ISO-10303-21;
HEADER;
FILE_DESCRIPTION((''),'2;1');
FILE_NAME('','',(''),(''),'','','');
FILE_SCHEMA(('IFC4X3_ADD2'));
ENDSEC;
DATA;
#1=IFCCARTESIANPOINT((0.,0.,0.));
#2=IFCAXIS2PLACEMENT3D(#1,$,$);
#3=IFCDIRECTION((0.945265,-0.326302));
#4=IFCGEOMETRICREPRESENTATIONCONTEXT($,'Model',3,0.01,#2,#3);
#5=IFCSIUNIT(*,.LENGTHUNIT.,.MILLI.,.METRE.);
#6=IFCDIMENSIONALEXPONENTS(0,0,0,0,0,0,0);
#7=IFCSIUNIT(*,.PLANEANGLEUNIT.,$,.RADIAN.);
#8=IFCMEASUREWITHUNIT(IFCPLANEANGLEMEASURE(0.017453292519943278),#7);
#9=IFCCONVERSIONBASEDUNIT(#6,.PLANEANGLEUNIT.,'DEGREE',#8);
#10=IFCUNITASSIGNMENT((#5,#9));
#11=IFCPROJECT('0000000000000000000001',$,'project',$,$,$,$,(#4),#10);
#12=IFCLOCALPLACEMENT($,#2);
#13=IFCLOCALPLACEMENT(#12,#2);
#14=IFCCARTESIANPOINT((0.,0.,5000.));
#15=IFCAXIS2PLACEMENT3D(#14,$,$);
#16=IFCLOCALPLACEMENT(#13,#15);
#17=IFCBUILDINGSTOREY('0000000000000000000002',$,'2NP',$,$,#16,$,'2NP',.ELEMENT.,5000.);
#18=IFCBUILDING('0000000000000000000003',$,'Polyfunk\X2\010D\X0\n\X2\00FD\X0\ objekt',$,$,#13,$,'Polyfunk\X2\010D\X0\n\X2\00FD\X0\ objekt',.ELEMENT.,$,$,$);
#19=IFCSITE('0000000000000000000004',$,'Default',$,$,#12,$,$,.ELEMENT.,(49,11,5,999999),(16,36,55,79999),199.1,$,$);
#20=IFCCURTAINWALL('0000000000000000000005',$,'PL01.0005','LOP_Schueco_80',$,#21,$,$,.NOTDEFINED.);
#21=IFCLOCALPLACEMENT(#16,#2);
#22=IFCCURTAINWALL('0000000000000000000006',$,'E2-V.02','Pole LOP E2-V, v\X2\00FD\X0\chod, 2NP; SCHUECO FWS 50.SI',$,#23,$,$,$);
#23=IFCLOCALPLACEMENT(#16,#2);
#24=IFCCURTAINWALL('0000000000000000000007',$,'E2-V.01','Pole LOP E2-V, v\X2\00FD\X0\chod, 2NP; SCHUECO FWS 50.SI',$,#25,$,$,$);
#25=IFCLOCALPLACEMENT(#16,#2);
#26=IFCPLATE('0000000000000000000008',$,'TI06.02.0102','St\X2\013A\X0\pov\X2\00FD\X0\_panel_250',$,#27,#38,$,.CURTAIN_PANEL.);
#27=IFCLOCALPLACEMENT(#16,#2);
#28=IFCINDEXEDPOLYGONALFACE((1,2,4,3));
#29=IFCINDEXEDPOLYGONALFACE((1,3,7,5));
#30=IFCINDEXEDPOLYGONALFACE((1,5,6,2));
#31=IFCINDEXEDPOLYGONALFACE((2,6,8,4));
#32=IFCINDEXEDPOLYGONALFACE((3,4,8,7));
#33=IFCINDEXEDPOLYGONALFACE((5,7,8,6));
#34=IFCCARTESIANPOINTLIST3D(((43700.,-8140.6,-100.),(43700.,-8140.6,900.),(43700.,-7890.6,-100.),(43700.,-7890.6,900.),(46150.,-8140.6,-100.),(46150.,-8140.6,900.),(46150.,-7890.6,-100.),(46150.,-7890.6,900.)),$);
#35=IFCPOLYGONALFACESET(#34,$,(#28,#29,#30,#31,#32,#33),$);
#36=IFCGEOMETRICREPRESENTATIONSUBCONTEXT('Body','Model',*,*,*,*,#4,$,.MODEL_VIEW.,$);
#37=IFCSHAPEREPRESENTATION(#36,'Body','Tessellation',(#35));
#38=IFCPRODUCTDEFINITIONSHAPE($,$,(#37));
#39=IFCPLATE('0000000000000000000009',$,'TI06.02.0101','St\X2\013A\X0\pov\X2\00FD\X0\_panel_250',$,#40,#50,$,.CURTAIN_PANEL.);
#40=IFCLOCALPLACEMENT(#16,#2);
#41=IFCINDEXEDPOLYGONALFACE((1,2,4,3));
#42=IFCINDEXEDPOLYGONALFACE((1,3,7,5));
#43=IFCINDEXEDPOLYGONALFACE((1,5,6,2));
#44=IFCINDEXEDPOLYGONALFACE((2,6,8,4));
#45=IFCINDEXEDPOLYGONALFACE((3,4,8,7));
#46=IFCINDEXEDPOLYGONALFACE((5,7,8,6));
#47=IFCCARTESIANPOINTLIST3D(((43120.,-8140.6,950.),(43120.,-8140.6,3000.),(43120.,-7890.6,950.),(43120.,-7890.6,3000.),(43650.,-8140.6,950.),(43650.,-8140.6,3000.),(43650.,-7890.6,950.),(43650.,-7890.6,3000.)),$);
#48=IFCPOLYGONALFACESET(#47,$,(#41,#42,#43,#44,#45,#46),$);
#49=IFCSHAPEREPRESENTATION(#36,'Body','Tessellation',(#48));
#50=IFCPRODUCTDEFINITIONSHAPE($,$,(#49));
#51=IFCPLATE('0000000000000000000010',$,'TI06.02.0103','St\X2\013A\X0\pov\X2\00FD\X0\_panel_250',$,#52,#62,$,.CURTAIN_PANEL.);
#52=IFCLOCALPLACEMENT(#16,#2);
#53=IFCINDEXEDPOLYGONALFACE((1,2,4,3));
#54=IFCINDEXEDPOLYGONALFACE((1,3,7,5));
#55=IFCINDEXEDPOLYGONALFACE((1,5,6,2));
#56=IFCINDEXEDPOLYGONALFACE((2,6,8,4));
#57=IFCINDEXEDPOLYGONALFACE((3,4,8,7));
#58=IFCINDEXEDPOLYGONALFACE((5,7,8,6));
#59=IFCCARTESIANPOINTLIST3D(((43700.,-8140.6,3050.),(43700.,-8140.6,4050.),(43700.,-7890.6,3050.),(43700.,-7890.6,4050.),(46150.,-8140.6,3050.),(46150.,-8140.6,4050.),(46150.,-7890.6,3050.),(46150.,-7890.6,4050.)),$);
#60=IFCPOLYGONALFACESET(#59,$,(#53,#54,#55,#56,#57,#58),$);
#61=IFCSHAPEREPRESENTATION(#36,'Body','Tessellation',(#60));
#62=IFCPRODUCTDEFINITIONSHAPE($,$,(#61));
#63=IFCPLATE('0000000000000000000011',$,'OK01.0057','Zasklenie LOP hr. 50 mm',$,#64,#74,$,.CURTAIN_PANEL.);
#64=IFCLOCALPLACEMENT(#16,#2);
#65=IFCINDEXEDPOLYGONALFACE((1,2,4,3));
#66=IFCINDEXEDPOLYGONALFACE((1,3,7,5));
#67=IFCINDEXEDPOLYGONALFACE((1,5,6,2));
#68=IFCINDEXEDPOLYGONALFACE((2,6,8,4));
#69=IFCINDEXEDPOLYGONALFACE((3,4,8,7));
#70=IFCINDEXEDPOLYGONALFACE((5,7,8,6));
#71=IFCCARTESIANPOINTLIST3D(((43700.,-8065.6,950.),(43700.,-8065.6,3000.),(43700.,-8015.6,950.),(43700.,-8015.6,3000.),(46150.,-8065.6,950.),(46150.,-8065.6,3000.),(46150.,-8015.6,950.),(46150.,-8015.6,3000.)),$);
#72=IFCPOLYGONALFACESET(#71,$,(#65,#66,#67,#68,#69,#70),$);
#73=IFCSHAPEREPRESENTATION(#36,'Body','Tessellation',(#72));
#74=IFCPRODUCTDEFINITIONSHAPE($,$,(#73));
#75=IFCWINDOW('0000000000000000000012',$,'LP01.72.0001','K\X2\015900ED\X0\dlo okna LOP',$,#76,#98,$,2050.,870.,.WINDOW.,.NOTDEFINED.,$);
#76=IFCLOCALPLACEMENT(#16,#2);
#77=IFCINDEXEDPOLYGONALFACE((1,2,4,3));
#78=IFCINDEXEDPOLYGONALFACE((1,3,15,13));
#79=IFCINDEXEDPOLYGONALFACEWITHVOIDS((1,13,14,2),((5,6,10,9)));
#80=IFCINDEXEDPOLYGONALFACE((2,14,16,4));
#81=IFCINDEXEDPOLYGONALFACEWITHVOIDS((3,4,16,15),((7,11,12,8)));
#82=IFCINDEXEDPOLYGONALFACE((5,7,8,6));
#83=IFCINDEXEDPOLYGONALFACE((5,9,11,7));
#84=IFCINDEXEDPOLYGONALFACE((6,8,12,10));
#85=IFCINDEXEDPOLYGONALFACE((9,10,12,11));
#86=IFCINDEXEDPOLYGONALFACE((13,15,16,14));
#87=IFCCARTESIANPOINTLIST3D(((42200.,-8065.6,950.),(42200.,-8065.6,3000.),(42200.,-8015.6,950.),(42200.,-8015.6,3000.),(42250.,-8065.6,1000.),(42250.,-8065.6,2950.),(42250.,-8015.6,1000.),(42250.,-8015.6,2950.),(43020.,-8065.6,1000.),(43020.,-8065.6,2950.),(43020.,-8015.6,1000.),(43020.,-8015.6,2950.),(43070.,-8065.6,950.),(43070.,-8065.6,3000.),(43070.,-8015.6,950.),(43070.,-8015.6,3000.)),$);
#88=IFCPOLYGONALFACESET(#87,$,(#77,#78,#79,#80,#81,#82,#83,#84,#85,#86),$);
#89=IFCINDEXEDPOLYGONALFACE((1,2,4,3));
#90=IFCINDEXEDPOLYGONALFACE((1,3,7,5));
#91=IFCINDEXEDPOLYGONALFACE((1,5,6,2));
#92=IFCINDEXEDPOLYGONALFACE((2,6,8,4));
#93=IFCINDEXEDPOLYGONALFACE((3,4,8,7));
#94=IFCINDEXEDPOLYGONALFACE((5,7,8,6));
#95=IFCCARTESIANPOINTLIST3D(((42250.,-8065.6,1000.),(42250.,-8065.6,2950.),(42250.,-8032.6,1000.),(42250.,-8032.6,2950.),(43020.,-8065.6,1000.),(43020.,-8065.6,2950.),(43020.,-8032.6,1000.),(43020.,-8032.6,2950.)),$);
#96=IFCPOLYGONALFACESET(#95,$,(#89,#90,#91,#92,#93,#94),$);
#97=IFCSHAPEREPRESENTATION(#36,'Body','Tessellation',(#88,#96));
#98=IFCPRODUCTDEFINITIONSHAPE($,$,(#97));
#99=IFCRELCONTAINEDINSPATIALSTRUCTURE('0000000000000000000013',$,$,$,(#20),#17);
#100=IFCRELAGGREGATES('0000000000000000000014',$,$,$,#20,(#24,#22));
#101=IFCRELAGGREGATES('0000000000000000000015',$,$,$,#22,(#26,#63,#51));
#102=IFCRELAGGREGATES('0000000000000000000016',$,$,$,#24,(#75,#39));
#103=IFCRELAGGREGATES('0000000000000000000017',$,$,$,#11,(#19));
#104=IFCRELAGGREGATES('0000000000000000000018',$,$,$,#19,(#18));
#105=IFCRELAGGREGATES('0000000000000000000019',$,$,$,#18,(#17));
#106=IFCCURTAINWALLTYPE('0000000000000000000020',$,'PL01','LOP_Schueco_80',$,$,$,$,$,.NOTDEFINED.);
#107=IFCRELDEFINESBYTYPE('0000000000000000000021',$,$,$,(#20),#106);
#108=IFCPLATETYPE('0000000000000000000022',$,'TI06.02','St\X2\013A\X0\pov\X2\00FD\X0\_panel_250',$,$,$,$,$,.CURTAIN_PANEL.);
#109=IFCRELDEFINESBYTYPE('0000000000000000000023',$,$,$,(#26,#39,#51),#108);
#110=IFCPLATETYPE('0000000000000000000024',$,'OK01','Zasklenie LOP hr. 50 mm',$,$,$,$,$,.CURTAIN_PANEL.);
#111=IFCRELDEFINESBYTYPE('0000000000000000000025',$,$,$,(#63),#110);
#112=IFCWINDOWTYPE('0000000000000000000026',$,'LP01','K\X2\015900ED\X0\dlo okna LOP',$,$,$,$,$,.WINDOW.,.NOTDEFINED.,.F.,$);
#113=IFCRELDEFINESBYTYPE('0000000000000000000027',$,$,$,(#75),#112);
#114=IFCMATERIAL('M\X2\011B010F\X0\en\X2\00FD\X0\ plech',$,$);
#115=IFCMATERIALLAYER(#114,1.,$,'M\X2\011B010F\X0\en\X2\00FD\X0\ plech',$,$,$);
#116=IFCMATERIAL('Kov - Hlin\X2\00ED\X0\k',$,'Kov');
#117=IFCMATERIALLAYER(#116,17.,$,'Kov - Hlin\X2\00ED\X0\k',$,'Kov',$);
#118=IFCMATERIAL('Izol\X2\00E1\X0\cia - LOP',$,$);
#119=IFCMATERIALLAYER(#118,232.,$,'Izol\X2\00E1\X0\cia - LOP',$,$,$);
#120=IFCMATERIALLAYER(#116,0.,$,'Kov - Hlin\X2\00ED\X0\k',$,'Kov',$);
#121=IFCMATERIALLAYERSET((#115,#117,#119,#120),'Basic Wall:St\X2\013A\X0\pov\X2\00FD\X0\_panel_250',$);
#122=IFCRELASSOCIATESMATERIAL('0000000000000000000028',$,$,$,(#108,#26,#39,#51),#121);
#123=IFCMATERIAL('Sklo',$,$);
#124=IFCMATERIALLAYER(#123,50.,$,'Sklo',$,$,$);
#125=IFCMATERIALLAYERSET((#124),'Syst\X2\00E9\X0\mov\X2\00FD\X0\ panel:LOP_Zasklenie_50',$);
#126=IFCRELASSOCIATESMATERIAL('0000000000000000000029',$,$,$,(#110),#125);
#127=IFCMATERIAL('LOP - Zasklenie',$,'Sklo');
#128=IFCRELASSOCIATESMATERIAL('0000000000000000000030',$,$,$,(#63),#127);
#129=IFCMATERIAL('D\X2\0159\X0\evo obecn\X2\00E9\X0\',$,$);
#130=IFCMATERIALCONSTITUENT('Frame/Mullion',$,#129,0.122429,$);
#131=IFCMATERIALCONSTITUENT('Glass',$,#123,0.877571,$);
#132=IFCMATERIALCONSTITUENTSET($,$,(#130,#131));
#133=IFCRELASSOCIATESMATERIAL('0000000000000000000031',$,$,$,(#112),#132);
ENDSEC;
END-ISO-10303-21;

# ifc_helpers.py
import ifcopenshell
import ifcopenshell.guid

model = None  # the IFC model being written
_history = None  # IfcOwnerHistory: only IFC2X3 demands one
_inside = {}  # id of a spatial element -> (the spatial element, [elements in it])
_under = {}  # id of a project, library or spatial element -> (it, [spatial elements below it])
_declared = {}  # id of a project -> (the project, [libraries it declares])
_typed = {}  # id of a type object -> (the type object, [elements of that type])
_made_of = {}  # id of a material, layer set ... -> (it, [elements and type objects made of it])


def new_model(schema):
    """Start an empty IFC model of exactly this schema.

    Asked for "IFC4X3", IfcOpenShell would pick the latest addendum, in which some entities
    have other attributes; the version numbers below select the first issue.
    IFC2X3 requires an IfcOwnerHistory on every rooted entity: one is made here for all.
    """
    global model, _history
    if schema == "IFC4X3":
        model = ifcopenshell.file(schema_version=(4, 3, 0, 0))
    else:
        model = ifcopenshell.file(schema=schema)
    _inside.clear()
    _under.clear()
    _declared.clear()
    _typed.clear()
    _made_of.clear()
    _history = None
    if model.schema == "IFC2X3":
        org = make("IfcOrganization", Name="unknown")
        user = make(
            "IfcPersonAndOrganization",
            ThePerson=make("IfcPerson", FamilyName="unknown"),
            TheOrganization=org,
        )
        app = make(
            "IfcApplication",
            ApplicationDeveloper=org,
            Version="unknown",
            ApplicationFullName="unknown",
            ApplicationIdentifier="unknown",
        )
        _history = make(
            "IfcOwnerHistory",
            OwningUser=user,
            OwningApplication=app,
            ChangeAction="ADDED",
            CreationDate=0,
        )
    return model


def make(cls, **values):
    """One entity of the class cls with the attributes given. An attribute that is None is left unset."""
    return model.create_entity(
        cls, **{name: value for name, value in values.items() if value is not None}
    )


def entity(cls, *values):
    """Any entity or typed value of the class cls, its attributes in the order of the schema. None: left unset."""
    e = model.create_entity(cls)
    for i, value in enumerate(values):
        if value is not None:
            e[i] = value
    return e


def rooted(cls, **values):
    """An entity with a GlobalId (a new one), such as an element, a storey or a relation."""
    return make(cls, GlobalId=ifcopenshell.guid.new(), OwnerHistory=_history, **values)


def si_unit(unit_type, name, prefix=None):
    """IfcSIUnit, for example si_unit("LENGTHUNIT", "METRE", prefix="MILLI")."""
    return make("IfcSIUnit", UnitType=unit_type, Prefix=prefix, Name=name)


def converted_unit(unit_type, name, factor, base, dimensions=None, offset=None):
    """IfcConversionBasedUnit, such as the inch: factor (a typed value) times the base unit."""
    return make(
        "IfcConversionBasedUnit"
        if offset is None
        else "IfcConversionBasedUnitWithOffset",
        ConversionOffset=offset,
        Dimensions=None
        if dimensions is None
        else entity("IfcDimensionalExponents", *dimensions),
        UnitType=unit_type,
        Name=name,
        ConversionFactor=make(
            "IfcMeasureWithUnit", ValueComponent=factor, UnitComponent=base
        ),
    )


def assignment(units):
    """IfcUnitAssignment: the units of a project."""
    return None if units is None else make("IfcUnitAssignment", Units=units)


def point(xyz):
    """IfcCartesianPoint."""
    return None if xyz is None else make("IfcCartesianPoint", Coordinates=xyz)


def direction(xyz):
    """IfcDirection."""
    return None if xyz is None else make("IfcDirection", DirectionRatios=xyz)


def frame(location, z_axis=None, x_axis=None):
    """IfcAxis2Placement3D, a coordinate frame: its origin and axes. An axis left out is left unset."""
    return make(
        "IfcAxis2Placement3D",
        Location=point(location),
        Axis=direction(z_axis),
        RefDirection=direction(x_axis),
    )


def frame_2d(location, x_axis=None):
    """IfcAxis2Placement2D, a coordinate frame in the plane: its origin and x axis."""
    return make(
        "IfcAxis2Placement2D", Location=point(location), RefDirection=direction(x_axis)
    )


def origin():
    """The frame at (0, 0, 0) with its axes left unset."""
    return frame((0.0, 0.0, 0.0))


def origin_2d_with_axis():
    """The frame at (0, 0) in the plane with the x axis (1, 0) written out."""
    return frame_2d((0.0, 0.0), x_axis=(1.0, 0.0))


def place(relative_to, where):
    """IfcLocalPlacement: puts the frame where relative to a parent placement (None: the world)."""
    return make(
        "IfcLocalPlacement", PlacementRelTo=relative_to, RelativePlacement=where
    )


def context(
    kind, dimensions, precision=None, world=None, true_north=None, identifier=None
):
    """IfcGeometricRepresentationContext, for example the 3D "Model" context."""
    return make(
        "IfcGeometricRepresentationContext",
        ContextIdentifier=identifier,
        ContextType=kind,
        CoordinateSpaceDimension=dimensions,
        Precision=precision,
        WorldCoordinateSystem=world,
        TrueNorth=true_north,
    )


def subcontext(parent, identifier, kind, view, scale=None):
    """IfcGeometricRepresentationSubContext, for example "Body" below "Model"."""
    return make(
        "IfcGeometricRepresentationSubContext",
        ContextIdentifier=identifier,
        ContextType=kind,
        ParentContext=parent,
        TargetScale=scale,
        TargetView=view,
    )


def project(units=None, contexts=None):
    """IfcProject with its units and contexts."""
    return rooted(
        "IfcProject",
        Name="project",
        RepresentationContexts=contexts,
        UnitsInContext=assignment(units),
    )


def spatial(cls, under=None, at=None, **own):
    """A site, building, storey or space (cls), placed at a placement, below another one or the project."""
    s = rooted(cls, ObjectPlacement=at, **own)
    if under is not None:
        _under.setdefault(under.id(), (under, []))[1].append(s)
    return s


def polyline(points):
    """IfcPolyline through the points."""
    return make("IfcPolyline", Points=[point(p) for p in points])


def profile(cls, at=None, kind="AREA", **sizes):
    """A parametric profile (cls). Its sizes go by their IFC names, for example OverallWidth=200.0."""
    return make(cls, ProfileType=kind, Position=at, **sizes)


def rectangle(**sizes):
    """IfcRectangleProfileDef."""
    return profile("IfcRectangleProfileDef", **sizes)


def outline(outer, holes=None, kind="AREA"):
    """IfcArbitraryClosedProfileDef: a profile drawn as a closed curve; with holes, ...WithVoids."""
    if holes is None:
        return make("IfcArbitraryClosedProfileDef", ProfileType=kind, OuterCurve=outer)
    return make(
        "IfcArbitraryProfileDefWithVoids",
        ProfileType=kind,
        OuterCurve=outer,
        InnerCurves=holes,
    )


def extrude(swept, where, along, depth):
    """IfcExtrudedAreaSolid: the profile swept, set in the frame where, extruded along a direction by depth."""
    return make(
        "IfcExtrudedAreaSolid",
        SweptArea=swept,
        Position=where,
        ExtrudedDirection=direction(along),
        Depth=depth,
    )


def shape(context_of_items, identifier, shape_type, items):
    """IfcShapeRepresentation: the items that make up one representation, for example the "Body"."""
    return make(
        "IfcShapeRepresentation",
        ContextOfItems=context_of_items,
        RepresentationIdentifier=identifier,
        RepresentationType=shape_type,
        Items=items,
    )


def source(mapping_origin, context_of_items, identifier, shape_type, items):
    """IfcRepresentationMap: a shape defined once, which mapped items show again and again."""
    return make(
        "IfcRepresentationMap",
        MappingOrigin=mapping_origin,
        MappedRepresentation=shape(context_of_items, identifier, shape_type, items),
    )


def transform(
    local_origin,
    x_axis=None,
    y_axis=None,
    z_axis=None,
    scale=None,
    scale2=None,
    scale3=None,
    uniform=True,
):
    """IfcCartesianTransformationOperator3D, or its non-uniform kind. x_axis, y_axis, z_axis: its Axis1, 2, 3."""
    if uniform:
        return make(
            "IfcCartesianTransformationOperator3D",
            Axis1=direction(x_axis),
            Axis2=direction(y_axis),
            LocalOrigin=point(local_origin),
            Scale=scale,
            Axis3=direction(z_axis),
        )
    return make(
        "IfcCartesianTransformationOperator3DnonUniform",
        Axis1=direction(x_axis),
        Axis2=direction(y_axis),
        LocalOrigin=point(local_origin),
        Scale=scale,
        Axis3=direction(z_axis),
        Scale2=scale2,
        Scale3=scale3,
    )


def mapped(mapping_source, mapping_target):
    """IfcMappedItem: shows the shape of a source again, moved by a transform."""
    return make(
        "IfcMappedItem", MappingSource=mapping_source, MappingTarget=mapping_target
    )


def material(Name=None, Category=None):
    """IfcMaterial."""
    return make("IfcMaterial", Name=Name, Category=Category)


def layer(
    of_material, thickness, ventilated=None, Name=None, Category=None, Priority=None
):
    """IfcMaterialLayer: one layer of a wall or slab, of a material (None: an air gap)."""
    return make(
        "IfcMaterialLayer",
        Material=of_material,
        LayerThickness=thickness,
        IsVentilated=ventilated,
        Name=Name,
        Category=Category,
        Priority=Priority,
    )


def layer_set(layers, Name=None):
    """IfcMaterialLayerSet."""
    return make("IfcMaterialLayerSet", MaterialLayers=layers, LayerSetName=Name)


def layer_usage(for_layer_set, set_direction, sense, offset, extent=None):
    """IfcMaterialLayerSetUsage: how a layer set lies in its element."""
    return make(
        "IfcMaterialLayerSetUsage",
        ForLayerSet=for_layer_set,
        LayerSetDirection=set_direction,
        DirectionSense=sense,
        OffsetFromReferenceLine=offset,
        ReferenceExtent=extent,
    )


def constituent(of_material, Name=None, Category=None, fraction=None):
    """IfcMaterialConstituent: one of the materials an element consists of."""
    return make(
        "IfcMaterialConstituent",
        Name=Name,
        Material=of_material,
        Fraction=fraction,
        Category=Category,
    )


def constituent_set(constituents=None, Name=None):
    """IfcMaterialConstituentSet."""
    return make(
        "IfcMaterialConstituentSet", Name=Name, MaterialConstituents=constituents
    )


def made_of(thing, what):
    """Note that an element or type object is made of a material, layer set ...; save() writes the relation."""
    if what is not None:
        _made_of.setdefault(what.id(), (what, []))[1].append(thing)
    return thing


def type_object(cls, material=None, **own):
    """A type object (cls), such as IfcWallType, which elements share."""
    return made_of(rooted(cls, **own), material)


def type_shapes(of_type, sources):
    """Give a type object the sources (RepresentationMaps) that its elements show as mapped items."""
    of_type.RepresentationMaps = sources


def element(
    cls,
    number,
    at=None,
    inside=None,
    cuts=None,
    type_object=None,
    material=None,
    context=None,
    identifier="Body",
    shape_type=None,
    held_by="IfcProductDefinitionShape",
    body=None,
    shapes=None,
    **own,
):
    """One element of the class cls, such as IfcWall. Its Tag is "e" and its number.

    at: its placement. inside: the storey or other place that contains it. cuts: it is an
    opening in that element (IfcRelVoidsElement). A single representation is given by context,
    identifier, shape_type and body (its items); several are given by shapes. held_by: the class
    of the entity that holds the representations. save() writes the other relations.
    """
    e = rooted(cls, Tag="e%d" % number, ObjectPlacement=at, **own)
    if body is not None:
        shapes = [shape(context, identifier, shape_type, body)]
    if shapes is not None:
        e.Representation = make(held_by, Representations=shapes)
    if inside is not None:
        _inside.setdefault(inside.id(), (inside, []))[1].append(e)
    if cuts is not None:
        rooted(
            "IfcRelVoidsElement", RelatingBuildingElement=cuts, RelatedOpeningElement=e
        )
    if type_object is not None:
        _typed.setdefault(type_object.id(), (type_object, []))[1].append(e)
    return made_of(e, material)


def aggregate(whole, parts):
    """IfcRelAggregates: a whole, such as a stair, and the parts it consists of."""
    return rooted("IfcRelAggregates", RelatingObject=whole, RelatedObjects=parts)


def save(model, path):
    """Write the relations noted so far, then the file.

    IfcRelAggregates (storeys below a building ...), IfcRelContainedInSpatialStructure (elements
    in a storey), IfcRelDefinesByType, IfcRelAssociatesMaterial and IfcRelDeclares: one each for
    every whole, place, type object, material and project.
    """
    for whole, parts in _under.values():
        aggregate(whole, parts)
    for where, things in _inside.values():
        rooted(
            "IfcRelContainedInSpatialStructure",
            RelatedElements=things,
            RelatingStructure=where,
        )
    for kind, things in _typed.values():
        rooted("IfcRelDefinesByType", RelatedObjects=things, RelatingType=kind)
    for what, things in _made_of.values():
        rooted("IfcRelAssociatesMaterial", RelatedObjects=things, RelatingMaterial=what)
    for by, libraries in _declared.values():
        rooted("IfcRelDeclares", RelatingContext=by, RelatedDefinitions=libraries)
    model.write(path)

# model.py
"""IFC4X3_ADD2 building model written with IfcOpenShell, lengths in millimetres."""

from ifc_helpers import new_model, entity, si_unit, converted_unit, direction, frame, frame_2d, origin, origin_2d_with_axis, place, context, subcontext, project, spatial, polyline, rectangle, outline, extrude, source, transform, mapped, material, layer, layer_set, layer_usage, constituent, constituent_set, type_object, type_shapes, element, aggregate, save


model = new_model("IFC4X3_ADD2")

# Units and contexts
model_context = context("Model", 3, precision=0.01, world=origin(), true_north=direction((0.945265, -0.326302)))
body_context = subcontext(model_context, "Body", "Model", "MODEL_VIEW")
ifc_project = project(units=[si_unit("LENGTHUNIT", "METRE", prefix="MILLI"), converted_unit("PLANEANGLEUNIT", "DEGREE", entity("IfcPlaneAngleMeasure", 0.017453292519943278), si_unit("PLANEANGLEUNIT", "RADIAN"), dimensions=[0, 0, 0, 0, 0, 0, 0])], contexts=[model_context])

# Site, building, storey
site_placement = place(None, origin())
site = spatial("IfcSite", under=ifc_project, at=site_placement, Name="Default", CompositionType="ELEMENT", RefLatitude=(49, 11, 5, 999999), RefLongitude=(16, 36, 55, 79999), RefElevation=199.1)
building_placement = place(site_placement, origin())
building = spatial("IfcBuilding", under=site, at=building_placement, Name="Polyfunkčný objekt", LongName="Polyfunkčný objekt", CompositionType="ELEMENT")
storey_placement = place(building_placement, frame((0.0, 0.0, 5000.0)))
storey = spatial("IfcBuildingStorey", under=building, at=storey_placement, Name="2NP", LongName="2NP", CompositionType="ELEMENT", Elevation=5000.0)

# Curtain walls, plates, window
curtain_wall_type = type_object("IfcCurtainWallType", Name="PL01", Description="LOP_Schueco_80", PredefinedType="NOTDEFINED")
curtain_wall_1_placement = place(storey_placement, frame((0.0, 0.0, -5000.0)))
curtain_wall_1 = element("IfcCurtainWall", 1, at=curtain_wall_1_placement, inside=storey, type_object=curtain_wall_type, Name="PL01.0005", Description="LOP_Schueco_80", PredefinedType="NOTDEFINED")
curtain_wall_2 = element("IfcCurtainWall", 2, Name="E2-V.02", Description="Pole LOP E2-V, východ, 2NP; SCHUECO FWS 50.SI")
curtain_wall_3 = element("IfcCurtainWall", 3, Name="E2-V.01", Description="Pole LOP E2-V, východ, 2NP; SCHUECO FWS 50.SI")
aggregate(curtain_wall_1, [curtain_wall_3, curtain_wall_2])
ifc_material_1 = material(Name="Měďený plech")
ifc_layer_1 = layer(ifc_material_1, 1.0, Name="Měďený plech")
ifc_material_2 = material(Name="Kov - Hliník", Category="Kov")
ifc_layer_2 = layer(ifc_material_2, 17.0, Name="Kov - Hliník", Category="Kov")
ifc_material_3 = material(Name="Izolácia - LOP")
ifc_layer_3 = layer(ifc_material_3, 232.0, Name="Izolácia - LOP")
ifc_layer_4 = layer(ifc_material_2, 0.0, Name="Kov - Hliník", Category="Kov")
ifc_layer_set_1 = layer_set([ifc_layer_1, ifc_layer_2, ifc_layer_3, ifc_layer_4], Name="Basic Wall:Stĺpový_panel_250")
ifc_layer_usage_1 = layer_usage(ifc_layer_set_1, "AXIS2", "POSITIVE", -125.0)
plate_type_1 = type_object("IfcPlateType", Name="TI06.02", Description="Stĺpový_panel_250", PredefinedType="CURTAIN_PANEL", material=ifc_layer_set_1)
plate_1_placement = place(storey_placement, frame((43700.0, -8015.6, -100.0)))
plate_1 = element("IfcPlate", 4, at=plate_1_placement, type_object=plate_type_1, material=ifc_layer_usage_1, Name="TI06.02.0102", Description="Stĺpový_panel_250", PredefinedType="CURTAIN_PANEL", context=body_context, shape_type="SweptSolid", body=[
    extrude(rectangle(XDim=250.0, YDim=2450.0, at=frame_2d((0.0, 0.0), x_axis=(1.0, 0.0))), frame((1225.0, 0.0, 0.0), z_axis=(0.0, 0.0, 1.0), x_axis=(0.0, 1.0, 0.0)), (0.0, 0.0, 1.0), 1000.0),
])
ifc_layer_usage_2 = layer_usage(ifc_layer_set_1, "AXIS2", "POSITIVE", -125.0)
plate_2_placement = place(storey_placement, frame((43120.0, -8015.6, 950.0)))
plate_2 = element("IfcPlate", 5, at=plate_2_placement, type_object=plate_type_1, material=ifc_layer_usage_2, Name="TI06.02.0101", Description="Stĺpový_panel_250", PredefinedType="CURTAIN_PANEL", context=body_context, shape_type="SweptSolid", body=[
    extrude(rectangle(XDim=250.0, YDim=530.0, at=frame_2d((0.0, 0.0), x_axis=(1.0, 0.0))), frame((265.0, 0.0, 0.0), z_axis=(0.0, 0.0, 1.0), x_axis=(0.0, 1.0, 0.0)), (0.0, 0.0, 1.0), 2050.0),
])
ifc_layer_usage_3 = layer_usage(ifc_layer_set_1, "AXIS2", "POSITIVE", -125.0)
plate_3_placement = place(storey_placement, frame((43700.0, -8015.6, 3050.0)))
plate_3 = element("IfcPlate", 6, at=plate_3_placement, type_object=plate_type_1, material=ifc_layer_usage_3, Name="TI06.02.0103", Description="Stĺpový_panel_250", PredefinedType="CURTAIN_PANEL", context=body_context, shape_type="SweptSolid", body=[
    extrude(rectangle(XDim=250.0, YDim=2450.0, at=frame_2d((0.0, 0.0), x_axis=(1.0, 0.0))), frame((1225.0, 0.0, 0.0), z_axis=(0.0, 0.0, 1.0), x_axis=(0.0, 1.0, 0.0)), (0.0, 0.0, 1.0), 1000.0),
])
ifc_material_4 = material(Name="LOP - Zasklenie", Category="Sklo")
ifc_material_5 = material(Name="Sklo")
ifc_layer_5 = layer(ifc_material_5, 50.0, Name="Sklo")
ifc_layer_set_2 = layer_set([ifc_layer_5], Name="Systémový panel:LOP_Zasklenie_50")
plate_type_2 = type_object("IfcPlateType", Name="OK01", Description="Zasklenie LOP hr. 50 mm", PredefinedType="CURTAIN_PANEL", material=ifc_layer_set_2)
shared_shape_1 = source(origin(), body_context, "Body", "SweptSolid", [
    extrude(rectangle(XDim=50.0, YDim=2450.0, at=origin_2d_with_axis()), frame((0.0, -25.0, 0.0), z_axis=(0.0, 0.0, 1.0), x_axis=(0.0, 1.0, 0.0)), (0.0, 0.0, 1.0), 2050.0),
])
type_shapes(plate_type_2, [shared_shape_1])
plate_4_placement = place(curtain_wall_1_placement, frame((44925.0, -8015.6, 5950.0)))
plate_4 = element("IfcPlate", 7, at=plate_4_placement, type_object=plate_type_2, material=ifc_material_4, Name="OK01.0057", Description="Zasklenie LOP hr. 50 mm", PredefinedType="CURTAIN_PANEL", context=body_context, shape_type="MappedRepresentation", body=[
    mapped(shared_shape_1, transform((0.0, 0.0, 0.0), scale=1.0)),
])
aggregate(curtain_wall_2, [plate_1, plate_4, plate_3])
ifc_material_6 = material(Name="Dřevo obecné")
ifc_constituent_1 = constituent(ifc_material_6, Name="Frame/Mullion", fraction=0.122429)
ifc_constituent_2 = constituent(ifc_material_5, Name="Glass", fraction=0.877571)
ifc_constituent_set = constituent_set(constituents=[ifc_constituent_1, ifc_constituent_2])
window_type = type_object("IfcWindowType", Name="LP01", Description="Křídlo okna LOP", ParameterTakesPrecedence=False, PartitioningType="NOTDEFINED", PredefinedType="WINDOW", material=ifc_constituent_set)
shared_shape_2 = source(origin(), body_context, "Body", "SweptSolid", [
    extrude(outline(polyline([(-1025.0, -435.0), (1025.0, -435.0), (1025.0, 435.0), (-1025.0, 435.0), (-1025.0, -435.0)]), holes=[polyline([(-975.0, -385.0), (-975.0, 385.0), (975.0, 385.0), (975.0, -385.0), (-975.0, -385.0)])]), frame((0.0, 50.0, 1025.0), z_axis=(0.0, -1.0, 0.0), x_axis=(0.0, 0.0, -1.0)), (0.0, 0.0, 1.0), 50.0),
    extrude(rectangle(XDim=770.0, YDim=33.0, at=frame_2d((0.0, 0.0), x_axis=(1.0, 0.0))), frame((0.0, 33.5, 50.0), z_axis=(0.0, 0.0, 1.0), x_axis=(-1.0, 0.0, 0.0)), (0.0, 0.0, 1.0), 1950.0),
])
type_shapes(window_type, [shared_shape_2])
window_placement = place(curtain_wall_1_placement, frame((42635.0, -8015.6, 5950.0), z_axis=(0.0, 0.0, 1.0), x_axis=(-1.0, 0.0, 0.0)))
window = element("IfcWindow", 8, at=window_placement, type_object=window_type, Name="LP01.72.0001", Description="Křídlo okna LOP", OverallHeight=2050.0, OverallWidth=870.0, PartitioningType="NOTDEFINED", PredefinedType="WINDOW", context=body_context, shape_type="MappedRepresentation", body=[
    mapped(shared_shape_2, transform((0.0, 0.0, 0.0), scale=1.0)),
])
aggregate(curtain_wall_3, [window, plate_2])

save(model, "model.ifc")
